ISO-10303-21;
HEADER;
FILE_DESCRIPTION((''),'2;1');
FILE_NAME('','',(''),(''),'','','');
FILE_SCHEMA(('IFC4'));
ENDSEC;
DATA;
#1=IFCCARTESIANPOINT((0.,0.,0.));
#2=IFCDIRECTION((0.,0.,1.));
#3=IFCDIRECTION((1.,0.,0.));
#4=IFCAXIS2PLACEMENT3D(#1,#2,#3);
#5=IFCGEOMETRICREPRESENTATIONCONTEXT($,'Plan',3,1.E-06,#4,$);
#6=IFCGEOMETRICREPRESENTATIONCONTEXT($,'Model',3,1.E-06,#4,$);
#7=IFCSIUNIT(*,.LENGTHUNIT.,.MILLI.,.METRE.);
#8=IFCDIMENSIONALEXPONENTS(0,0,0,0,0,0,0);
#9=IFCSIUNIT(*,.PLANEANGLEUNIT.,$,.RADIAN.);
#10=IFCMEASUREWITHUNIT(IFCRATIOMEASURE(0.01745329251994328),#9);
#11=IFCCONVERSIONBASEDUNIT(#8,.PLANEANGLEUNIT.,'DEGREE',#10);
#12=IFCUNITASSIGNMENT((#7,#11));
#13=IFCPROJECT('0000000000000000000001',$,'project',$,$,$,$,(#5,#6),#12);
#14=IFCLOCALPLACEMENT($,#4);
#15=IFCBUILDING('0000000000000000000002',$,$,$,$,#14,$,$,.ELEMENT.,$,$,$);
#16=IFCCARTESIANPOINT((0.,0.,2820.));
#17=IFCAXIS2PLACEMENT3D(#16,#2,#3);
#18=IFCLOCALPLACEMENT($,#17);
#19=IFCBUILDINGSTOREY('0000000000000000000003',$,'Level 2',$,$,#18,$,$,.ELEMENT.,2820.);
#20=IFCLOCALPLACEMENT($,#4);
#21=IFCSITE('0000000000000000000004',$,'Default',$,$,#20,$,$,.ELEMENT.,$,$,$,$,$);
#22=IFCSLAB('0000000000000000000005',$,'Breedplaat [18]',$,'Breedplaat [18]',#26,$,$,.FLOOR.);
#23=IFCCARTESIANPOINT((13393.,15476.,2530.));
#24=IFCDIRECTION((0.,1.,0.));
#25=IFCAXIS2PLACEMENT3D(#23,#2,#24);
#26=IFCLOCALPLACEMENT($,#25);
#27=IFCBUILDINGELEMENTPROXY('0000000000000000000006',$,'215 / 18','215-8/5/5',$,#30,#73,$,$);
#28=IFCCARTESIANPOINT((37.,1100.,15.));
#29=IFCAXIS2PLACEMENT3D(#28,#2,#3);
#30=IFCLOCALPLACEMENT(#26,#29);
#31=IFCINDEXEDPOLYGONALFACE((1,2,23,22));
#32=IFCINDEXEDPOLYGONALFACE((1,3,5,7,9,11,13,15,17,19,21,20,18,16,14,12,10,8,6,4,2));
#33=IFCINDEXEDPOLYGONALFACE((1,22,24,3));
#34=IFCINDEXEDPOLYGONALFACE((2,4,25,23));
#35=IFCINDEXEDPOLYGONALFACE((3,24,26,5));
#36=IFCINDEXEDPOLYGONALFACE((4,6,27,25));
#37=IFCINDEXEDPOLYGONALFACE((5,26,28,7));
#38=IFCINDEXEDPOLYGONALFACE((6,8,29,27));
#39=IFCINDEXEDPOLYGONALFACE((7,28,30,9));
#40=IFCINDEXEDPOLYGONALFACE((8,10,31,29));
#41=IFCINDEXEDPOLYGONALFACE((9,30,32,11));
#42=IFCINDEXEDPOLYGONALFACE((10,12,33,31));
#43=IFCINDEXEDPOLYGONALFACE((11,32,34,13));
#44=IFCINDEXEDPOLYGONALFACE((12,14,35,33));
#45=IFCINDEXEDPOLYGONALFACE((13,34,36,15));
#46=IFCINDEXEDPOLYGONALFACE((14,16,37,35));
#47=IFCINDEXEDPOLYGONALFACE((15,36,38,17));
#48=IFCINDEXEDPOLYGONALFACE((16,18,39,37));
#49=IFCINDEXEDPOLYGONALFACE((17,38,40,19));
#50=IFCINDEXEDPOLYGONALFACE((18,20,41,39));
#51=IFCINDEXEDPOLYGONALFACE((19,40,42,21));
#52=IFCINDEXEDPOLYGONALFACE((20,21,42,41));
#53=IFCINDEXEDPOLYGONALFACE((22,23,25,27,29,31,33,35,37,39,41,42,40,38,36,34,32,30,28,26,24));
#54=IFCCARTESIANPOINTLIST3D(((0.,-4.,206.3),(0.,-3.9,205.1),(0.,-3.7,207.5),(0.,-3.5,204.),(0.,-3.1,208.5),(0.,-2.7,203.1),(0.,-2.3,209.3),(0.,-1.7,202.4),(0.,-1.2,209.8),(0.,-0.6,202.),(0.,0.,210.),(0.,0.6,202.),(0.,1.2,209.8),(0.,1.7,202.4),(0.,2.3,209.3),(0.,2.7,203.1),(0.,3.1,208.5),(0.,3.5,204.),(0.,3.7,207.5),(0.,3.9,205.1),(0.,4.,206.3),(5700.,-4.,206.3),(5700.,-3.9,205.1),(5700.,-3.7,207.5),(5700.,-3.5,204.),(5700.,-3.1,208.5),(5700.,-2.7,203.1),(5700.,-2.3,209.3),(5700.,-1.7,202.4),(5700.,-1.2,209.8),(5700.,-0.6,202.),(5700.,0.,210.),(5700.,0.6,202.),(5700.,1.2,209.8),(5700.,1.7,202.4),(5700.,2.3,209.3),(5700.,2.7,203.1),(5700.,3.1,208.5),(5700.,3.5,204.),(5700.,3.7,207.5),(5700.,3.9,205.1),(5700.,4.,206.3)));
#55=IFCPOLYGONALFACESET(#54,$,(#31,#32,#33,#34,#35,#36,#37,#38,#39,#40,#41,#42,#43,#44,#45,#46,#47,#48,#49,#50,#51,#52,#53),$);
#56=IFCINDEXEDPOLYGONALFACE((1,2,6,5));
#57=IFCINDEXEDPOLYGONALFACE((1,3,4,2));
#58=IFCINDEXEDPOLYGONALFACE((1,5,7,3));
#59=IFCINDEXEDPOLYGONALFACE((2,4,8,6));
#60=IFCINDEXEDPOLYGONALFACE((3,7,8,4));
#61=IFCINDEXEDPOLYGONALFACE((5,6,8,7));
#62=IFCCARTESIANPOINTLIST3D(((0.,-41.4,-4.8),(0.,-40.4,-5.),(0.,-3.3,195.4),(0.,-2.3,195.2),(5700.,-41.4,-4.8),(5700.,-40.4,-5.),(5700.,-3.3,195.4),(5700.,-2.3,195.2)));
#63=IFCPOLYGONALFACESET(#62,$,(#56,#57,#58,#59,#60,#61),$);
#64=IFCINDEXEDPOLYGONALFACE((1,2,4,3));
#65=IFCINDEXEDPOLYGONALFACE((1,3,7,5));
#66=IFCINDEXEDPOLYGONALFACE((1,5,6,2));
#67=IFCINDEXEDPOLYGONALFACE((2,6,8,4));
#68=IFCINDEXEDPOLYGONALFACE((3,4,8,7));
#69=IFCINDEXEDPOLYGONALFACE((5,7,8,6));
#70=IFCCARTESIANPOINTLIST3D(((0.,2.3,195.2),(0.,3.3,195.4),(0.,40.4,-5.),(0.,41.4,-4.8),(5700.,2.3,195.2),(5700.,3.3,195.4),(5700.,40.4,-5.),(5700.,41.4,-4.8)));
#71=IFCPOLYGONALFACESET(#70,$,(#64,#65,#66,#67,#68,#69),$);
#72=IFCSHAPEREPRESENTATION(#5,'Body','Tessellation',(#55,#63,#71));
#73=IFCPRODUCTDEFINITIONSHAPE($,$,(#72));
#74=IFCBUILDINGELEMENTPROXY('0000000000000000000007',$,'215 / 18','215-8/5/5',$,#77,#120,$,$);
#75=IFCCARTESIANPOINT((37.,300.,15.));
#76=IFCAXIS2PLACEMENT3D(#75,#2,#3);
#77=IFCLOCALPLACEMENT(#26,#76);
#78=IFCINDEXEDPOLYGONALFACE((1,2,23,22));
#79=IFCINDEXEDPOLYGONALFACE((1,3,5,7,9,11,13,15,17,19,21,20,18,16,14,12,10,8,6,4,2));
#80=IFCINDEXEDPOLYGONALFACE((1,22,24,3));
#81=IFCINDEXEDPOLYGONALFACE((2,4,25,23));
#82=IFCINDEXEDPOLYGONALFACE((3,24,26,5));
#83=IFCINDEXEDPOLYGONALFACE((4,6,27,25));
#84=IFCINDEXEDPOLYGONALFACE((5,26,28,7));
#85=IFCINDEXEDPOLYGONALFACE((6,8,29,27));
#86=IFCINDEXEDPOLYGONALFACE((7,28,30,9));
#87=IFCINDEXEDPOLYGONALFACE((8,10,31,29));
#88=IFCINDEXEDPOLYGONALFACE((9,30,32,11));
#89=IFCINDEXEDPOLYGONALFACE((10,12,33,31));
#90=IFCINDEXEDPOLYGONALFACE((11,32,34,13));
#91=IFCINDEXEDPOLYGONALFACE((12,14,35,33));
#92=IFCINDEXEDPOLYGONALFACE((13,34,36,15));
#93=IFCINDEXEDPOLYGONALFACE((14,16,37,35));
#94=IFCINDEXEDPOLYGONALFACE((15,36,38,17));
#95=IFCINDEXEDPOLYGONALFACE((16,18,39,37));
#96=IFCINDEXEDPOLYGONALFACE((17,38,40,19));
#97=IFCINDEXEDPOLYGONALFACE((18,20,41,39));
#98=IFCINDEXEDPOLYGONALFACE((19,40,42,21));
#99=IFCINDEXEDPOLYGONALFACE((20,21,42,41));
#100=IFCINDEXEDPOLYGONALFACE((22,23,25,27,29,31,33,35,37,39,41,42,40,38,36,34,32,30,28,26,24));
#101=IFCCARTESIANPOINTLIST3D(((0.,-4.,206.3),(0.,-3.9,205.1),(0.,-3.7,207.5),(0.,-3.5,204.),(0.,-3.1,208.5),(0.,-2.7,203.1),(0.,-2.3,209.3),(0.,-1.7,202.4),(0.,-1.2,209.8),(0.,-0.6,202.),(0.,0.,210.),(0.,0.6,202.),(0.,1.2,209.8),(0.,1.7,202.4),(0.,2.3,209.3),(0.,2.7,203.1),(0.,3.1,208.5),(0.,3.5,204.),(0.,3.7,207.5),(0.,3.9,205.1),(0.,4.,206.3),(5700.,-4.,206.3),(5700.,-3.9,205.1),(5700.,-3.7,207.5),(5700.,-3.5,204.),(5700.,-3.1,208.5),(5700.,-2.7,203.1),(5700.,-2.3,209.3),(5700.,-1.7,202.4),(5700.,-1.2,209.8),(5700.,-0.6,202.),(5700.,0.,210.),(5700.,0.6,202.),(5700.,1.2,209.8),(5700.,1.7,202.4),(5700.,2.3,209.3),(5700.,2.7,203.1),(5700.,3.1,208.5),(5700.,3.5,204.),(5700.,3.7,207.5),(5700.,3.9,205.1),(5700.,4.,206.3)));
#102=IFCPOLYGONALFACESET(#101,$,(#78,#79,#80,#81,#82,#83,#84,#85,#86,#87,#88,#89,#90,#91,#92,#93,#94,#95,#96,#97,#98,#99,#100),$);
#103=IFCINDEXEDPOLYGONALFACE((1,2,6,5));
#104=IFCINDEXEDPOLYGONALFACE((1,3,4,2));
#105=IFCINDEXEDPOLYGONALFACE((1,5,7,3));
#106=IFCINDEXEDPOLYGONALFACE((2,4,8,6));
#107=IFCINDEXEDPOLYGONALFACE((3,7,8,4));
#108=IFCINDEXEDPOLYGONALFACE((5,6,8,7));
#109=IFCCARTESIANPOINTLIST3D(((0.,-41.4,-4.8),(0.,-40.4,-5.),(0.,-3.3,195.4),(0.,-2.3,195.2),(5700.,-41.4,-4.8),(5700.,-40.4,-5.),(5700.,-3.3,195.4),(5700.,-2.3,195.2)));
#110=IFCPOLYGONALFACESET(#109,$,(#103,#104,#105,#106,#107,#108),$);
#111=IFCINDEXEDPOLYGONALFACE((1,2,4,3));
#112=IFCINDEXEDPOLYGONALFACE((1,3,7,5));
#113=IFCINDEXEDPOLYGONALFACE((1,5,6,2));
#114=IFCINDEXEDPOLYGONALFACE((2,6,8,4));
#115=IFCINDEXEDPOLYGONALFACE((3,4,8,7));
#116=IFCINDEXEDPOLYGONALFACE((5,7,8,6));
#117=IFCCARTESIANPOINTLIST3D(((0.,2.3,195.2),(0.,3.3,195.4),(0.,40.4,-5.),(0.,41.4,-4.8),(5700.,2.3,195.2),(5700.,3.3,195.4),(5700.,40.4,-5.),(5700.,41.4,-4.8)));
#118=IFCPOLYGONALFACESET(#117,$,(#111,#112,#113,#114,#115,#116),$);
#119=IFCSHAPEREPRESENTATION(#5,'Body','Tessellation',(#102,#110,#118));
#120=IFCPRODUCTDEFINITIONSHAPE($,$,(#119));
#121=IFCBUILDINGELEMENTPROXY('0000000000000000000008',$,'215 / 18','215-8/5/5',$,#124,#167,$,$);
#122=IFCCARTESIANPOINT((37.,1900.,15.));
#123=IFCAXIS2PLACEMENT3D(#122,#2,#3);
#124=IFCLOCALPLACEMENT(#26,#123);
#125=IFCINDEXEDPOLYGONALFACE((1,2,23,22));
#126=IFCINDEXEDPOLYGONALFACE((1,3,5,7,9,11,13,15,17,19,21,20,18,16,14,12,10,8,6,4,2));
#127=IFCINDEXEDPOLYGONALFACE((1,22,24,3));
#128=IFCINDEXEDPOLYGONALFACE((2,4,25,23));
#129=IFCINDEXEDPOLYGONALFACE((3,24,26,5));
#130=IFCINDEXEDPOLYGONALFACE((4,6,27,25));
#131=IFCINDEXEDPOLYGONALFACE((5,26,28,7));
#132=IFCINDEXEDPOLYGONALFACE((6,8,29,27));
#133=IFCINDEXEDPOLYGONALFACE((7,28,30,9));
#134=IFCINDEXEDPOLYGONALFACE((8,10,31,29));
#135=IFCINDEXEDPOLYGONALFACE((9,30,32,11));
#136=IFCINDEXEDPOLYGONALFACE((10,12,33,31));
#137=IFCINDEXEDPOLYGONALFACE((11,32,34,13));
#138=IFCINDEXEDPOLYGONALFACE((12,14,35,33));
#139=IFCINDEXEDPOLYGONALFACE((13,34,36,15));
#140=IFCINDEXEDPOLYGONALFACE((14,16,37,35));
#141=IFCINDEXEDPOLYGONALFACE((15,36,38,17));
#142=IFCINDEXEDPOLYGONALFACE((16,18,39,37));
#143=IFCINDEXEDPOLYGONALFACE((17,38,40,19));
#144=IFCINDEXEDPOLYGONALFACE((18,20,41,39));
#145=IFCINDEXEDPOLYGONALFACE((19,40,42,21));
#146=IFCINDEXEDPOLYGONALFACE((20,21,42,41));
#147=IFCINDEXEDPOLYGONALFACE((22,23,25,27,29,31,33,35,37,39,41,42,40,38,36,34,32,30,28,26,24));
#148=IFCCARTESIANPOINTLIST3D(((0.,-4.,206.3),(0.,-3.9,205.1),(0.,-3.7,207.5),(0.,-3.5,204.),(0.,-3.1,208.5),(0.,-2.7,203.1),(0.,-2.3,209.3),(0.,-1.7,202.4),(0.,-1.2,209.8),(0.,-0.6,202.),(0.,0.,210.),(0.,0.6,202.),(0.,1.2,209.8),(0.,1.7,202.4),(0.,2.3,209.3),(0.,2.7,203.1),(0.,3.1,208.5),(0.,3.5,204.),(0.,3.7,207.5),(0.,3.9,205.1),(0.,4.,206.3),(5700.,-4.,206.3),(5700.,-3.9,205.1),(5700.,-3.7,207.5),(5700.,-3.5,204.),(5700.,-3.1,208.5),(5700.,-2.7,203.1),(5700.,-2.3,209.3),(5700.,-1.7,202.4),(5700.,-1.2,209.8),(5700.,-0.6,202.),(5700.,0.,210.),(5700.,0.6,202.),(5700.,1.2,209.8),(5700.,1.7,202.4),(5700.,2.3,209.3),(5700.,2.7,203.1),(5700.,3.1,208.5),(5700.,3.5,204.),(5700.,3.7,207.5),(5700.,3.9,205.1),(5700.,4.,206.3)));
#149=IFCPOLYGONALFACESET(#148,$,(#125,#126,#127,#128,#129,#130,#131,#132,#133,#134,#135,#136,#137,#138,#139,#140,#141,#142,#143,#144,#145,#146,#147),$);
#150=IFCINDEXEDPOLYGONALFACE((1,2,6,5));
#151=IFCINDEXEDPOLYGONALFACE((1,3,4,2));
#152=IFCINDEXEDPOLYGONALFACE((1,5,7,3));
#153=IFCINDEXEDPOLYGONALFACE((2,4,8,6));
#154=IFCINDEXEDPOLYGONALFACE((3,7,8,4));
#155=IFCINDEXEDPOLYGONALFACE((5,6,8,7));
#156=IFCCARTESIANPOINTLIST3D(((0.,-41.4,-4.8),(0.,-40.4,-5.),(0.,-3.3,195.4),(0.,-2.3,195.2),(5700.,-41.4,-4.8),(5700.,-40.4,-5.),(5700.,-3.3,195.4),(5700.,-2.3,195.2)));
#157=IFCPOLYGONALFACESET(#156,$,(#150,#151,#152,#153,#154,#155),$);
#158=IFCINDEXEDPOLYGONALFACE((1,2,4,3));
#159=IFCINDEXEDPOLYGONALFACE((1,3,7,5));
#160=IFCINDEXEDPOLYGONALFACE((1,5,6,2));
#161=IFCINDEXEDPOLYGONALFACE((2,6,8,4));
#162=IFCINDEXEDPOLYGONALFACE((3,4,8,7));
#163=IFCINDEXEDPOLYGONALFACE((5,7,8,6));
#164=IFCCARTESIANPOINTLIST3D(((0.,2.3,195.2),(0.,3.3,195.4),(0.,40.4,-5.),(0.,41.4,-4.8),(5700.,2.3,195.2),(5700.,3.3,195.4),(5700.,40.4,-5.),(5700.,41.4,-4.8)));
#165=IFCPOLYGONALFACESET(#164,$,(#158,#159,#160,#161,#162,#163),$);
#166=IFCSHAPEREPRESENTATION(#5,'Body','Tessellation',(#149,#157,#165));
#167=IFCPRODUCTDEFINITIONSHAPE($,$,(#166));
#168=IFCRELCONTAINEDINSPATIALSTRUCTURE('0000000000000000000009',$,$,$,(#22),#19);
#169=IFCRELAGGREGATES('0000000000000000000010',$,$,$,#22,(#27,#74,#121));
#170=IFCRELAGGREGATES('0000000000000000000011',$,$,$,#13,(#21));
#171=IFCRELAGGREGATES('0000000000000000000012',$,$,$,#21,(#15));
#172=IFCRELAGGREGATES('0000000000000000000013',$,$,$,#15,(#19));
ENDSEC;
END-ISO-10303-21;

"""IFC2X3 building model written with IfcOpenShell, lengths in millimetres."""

from ifc_helpers import new_model, entity, si_unit, converted_unit, frame, origin_with_axes, origin_2d_with_axis, place, context, project, spatial, rectangle, circle, extrude, element, aggregate, save


model = new_model("IFC2X3")

# Units and contexts
plan_context = context("Plan", 3, precision=1e-06, world=origin_with_axes())
model_context = context("Model", 3, precision=1e-06, world=origin_with_axes())
ifc_project = project(units=[si_unit("LENGTHUNIT", "METRE", prefix="MILLI"), converted_unit("PLANEANGLEUNIT", "DEGREE", entity("IfcRatioMeasure", 0.01745329251994328), si_unit("PLANEANGLEUNIT", "RADIAN"), dimensions=[0, 0, 0, 0, 0, 0, 0])], contexts=[plan_context, model_context])

# Site, building, storey
site_placement = place(None, origin_with_axes())
site = spatial("IfcSite", under=ifc_project, at=site_placement, Name="Default", CompositionType="ELEMENT")
building_placement = place(None, origin_with_axes())
building = spatial("IfcBuilding", under=site, at=building_placement, CompositionType="ELEMENT")
storey_placement = place(None, frame((0.0, 0.0, 2820.0), z_axis=(0.0, 0.0, 1.0), x_axis=(1.0, 0.0, 0.0)))
storey = spatial("IfcBuildingStorey", under=building, at=storey_placement, Name="Level 2", CompositionType="ELEMENT", Elevation=2820.0)

# Slab, building element proxies
slab_1_placement = place(None, frame((13393.0, 15476.0, 2530.0), z_axis=(0.0, 0.0, 1.0), x_axis=(0.0, 1.0, 0.0)))
slab_1 = element("IfcSlab", 1, at=slab_1_placement, inside=storey, Name="Breedplaat [18]", ObjectType="Breedplaat [18]", PredefinedType="FLOOR")
proxy_1_placement = place(slab_1_placement, frame((37.0, 1100.0, 15.0), z_axis=(0.0, 0.0, 1.0), x_axis=(1.0, 0.0, 0.0)))
proxy_1 = element("IfcBuildingElementProxy", 2, at=proxy_1_placement, Name="215 / 18", Description="215-8/5/5", context=plan_context, shape_type="SweptSolid", body=[
    extrude(circle(Radius=4.0, at=origin_2d_with_axis()), frame((0.0, 0.0, 206.0), z_axis=(1.0, 0.0, 0.0), x_axis=(0.0, 0.0, 1.0)), (0.0, 0.0, 1.0), 5700.0),
    extrude(rectangle(XDim=203.8, YDim=1.0, at=origin_2d_with_axis()), frame((0.0, -21.9, 95.2), z_axis=(1.0, 0.0, 0.0), x_axis=(0.0, 0.187112, 0.982339)), (0.0, 0.0, 1.0), 5700.0),
    extrude(rectangle(XDim=203.8, YDim=1.0, at=origin_2d_with_axis()), frame((0.0, 21.9, 95.2), z_axis=(1.0, 0.0, 0.0), x_axis=(0.0, -0.187112, 0.982339)), (0.0, 0.0, 1.0), 5700.0),
])
proxy_2_placement = place(slab_1_placement, frame((37.0, 300.0, 15.0), z_axis=(0.0, 0.0, 1.0), x_axis=(1.0, 0.0, 0.0)))
proxy_2 = element("IfcBuildingElementProxy", 3, at=proxy_2_placement, Name="215 / 18", Description="215-8/5/5", context=plan_context, shape_type="SweptSolid", body=[
    extrude(circle(Radius=4.0, at=origin_2d_with_axis()), frame((0.0, 0.0, 206.0), z_axis=(1.0, 0.0, 0.0), x_axis=(0.0, 0.0, 1.0)), (0.0, 0.0, 1.0), 5700.0),
    extrude(rectangle(XDim=203.8, YDim=1.0, at=origin_2d_with_axis()), frame((0.0, -21.9, 95.2), z_axis=(1.0, 0.0, 0.0), x_axis=(0.0, 0.187112, 0.982339)), (0.0, 0.0, 1.0), 5700.0),
    extrude(rectangle(XDim=203.8, YDim=1.0, at=origin_2d_with_axis()), frame((0.0, 21.9, 95.2), z_axis=(1.0, 0.0, 0.0), x_axis=(0.0, -0.187112, 0.982339)), (0.0, 0.0, 1.0), 5700.0),
])
proxy_3_placement = place(slab_1_placement, frame((37.0, 1900.0, 15.0), z_axis=(0.0, 0.0, 1.0), x_axis=(1.0, 0.0, 0.0)))
proxy_3 = element("IfcBuildingElementProxy", 4, at=proxy_3_placement, Name="215 / 18", Description="215-8/5/5", context=plan_context, shape_type="SweptSolid", body=[
    extrude(circle(Radius=4.0, at=origin_2d_with_axis()), frame((0.0, 0.0, 206.0), z_axis=(1.0, 0.0, 0.0), x_axis=(0.0, 0.0, 1.0)), (0.0, 0.0, 1.0), 5700.0),
    extrude(rectangle(XDim=203.8, YDim=1.0, at=origin_2d_with_axis()), frame((0.0, -21.9, 95.2), z_axis=(1.0, 0.0, 0.0), x_axis=(0.0, 0.187112, 0.982339)), (0.0, 0.0, 1.0), 5700.0),
    extrude(rectangle(XDim=203.8, YDim=1.0, at=origin_2d_with_axis()), frame((0.0, 21.9, 95.2), z_axis=(1.0, 0.0, 0.0), x_axis=(0.0, -0.187112, 0.982339)), (0.0, 0.0, 1.0), 5700.0),
])
aggregate(slab_1, [proxy_1, proxy_2, proxy_3])

save(model, "model.ifc")
